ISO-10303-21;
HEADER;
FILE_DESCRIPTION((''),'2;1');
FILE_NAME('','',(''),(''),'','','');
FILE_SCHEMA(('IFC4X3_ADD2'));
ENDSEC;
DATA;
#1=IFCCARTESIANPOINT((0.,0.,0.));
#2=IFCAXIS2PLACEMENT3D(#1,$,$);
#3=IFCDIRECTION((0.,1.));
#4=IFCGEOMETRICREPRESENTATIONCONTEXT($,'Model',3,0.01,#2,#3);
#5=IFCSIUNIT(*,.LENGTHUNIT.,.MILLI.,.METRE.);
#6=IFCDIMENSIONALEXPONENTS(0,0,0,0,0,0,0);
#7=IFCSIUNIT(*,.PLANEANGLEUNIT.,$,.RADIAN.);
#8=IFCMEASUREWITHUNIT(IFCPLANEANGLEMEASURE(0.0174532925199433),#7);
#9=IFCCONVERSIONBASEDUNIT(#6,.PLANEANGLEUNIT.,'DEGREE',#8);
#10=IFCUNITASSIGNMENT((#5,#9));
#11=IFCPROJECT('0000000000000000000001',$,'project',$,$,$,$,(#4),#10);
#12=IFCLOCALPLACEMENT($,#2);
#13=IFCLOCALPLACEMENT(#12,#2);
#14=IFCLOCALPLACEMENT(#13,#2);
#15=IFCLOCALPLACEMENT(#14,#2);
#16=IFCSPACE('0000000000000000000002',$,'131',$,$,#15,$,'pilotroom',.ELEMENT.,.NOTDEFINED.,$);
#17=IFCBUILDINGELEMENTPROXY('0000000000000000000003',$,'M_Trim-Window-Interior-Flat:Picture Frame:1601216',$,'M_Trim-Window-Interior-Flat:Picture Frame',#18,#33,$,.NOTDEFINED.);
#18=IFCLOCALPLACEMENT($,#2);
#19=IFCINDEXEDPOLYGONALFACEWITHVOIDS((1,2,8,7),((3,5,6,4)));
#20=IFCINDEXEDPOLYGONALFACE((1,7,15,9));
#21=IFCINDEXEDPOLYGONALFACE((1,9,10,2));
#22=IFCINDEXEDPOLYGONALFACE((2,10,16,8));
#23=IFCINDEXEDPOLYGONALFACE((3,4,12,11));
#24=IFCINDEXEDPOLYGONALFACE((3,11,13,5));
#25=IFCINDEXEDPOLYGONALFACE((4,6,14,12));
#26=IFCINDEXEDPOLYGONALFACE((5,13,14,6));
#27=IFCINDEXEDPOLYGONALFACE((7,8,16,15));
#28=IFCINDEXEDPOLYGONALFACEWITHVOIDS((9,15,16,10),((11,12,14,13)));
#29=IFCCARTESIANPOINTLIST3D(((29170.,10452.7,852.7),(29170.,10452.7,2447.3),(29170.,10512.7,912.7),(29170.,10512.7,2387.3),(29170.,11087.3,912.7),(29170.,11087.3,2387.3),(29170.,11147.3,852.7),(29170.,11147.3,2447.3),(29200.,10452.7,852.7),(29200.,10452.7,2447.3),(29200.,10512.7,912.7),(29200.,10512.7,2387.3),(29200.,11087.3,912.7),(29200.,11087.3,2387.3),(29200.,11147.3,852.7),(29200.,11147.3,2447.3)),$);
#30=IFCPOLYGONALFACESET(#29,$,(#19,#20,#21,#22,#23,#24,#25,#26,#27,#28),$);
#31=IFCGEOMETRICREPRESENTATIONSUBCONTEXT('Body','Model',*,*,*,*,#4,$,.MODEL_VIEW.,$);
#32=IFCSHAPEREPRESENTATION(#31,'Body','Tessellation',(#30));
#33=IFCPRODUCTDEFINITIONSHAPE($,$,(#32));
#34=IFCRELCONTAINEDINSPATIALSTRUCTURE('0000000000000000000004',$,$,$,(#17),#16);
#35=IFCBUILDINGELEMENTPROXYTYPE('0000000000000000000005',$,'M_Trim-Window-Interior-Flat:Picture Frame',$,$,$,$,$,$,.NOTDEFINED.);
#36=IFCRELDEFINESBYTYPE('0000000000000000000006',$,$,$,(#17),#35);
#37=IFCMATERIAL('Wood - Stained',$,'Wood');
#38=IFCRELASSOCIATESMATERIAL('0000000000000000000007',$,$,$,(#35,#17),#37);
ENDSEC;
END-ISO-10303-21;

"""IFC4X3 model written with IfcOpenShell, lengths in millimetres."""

from ifc_helpers import new_model, entity, si_unit, converted_unit, direction, frame, origin, place, context, subcontext, project, spatial, polyline, outline, extrude, source, transform, mapped, material, type_object, type_shapes, element, save


model = new_model("IFC4X3")

# Units and contexts
model_context = context("Model", 3, precision=0.01, world=origin(), true_north=direction((0.0, 1.0)))
body_context = subcontext(model_context, "Body", "Model", "MODEL_VIEW")
ifc_project = project(units=[si_unit("LENGTHUNIT", "METRE", prefix="MILLI"), converted_unit("PLANEANGLEUNIT", "DEGREE", entity("IfcPlaneAngleMeasure", 0.0174532925199433), si_unit("PLANEANGLEUNIT", "RADIAN"), dimensions=[0, 0, 0, 0, 0, 0, 0])], contexts=[model_context])

# Space
placement_1 = place(None, origin())
placement_2 = place(placement_1, origin())
placement_3 = place(placement_2, origin())
space_placement = place(placement_3, origin())
space = spatial("IfcSpace", at=space_placement, Name="131", LongName="pilotroom", CompositionType="ELEMENT", PredefinedType="NOTDEFINED")

# Building element proxy
ifc_material = material(Name="Wood - Stained", Category="Wood")
building_element_proxy_type = type_object("IfcBuildingElementProxyType", Name="M_Trim-Window-Interior-Flat:Picture Frame", PredefinedType="NOTDEFINED", material=ifc_material)
shared_shape = source(origin(), body_context, "Body", "SweptSolid", [
    extrude(outline(polyline([(-347.3, -797.3), (347.3, -797.3), (347.3, 797.3), (-347.3, 797.3), (-347.3, -797.3)]), holes=[polyline([(-287.3, -737.3), (-287.3, 737.3), (287.3, 737.3), (287.3, -737.3), (-287.3, -737.3)])]), frame((0.0, -750.0, 0.0), z_axis=(0.0, 0.0, 1.0), x_axis=(-1.0, 0.0, 0.0)), (0.0, 0.0, 1.0), 30.0),
])
type_shapes(building_element_proxy_type, [shared_shape])
proxy_placement = place(space_placement, frame((29200.0, 10800.0, 2400.0), z_axis=(-1.0, 0.0, 0.0), x_axis=(0.0, -1.0, 0.0)))
element("IfcBuildingElementProxy", 1, at=proxy_placement, inside=space, type_object=building_element_proxy_type, material=ifc_material, Name="M_Trim-Window-Interior-Flat:Picture Frame:1601216", ObjectType="M_Trim-Window-Interior-Flat:Picture Frame", PredefinedType="NOTDEFINED", context=body_context, shape_type="MappedRepresentation", body=[
    mapped(shared_shape, transform((0.0, 0.0, 0.0), scale=1.0)),
])

save(model, "model.ifc")
